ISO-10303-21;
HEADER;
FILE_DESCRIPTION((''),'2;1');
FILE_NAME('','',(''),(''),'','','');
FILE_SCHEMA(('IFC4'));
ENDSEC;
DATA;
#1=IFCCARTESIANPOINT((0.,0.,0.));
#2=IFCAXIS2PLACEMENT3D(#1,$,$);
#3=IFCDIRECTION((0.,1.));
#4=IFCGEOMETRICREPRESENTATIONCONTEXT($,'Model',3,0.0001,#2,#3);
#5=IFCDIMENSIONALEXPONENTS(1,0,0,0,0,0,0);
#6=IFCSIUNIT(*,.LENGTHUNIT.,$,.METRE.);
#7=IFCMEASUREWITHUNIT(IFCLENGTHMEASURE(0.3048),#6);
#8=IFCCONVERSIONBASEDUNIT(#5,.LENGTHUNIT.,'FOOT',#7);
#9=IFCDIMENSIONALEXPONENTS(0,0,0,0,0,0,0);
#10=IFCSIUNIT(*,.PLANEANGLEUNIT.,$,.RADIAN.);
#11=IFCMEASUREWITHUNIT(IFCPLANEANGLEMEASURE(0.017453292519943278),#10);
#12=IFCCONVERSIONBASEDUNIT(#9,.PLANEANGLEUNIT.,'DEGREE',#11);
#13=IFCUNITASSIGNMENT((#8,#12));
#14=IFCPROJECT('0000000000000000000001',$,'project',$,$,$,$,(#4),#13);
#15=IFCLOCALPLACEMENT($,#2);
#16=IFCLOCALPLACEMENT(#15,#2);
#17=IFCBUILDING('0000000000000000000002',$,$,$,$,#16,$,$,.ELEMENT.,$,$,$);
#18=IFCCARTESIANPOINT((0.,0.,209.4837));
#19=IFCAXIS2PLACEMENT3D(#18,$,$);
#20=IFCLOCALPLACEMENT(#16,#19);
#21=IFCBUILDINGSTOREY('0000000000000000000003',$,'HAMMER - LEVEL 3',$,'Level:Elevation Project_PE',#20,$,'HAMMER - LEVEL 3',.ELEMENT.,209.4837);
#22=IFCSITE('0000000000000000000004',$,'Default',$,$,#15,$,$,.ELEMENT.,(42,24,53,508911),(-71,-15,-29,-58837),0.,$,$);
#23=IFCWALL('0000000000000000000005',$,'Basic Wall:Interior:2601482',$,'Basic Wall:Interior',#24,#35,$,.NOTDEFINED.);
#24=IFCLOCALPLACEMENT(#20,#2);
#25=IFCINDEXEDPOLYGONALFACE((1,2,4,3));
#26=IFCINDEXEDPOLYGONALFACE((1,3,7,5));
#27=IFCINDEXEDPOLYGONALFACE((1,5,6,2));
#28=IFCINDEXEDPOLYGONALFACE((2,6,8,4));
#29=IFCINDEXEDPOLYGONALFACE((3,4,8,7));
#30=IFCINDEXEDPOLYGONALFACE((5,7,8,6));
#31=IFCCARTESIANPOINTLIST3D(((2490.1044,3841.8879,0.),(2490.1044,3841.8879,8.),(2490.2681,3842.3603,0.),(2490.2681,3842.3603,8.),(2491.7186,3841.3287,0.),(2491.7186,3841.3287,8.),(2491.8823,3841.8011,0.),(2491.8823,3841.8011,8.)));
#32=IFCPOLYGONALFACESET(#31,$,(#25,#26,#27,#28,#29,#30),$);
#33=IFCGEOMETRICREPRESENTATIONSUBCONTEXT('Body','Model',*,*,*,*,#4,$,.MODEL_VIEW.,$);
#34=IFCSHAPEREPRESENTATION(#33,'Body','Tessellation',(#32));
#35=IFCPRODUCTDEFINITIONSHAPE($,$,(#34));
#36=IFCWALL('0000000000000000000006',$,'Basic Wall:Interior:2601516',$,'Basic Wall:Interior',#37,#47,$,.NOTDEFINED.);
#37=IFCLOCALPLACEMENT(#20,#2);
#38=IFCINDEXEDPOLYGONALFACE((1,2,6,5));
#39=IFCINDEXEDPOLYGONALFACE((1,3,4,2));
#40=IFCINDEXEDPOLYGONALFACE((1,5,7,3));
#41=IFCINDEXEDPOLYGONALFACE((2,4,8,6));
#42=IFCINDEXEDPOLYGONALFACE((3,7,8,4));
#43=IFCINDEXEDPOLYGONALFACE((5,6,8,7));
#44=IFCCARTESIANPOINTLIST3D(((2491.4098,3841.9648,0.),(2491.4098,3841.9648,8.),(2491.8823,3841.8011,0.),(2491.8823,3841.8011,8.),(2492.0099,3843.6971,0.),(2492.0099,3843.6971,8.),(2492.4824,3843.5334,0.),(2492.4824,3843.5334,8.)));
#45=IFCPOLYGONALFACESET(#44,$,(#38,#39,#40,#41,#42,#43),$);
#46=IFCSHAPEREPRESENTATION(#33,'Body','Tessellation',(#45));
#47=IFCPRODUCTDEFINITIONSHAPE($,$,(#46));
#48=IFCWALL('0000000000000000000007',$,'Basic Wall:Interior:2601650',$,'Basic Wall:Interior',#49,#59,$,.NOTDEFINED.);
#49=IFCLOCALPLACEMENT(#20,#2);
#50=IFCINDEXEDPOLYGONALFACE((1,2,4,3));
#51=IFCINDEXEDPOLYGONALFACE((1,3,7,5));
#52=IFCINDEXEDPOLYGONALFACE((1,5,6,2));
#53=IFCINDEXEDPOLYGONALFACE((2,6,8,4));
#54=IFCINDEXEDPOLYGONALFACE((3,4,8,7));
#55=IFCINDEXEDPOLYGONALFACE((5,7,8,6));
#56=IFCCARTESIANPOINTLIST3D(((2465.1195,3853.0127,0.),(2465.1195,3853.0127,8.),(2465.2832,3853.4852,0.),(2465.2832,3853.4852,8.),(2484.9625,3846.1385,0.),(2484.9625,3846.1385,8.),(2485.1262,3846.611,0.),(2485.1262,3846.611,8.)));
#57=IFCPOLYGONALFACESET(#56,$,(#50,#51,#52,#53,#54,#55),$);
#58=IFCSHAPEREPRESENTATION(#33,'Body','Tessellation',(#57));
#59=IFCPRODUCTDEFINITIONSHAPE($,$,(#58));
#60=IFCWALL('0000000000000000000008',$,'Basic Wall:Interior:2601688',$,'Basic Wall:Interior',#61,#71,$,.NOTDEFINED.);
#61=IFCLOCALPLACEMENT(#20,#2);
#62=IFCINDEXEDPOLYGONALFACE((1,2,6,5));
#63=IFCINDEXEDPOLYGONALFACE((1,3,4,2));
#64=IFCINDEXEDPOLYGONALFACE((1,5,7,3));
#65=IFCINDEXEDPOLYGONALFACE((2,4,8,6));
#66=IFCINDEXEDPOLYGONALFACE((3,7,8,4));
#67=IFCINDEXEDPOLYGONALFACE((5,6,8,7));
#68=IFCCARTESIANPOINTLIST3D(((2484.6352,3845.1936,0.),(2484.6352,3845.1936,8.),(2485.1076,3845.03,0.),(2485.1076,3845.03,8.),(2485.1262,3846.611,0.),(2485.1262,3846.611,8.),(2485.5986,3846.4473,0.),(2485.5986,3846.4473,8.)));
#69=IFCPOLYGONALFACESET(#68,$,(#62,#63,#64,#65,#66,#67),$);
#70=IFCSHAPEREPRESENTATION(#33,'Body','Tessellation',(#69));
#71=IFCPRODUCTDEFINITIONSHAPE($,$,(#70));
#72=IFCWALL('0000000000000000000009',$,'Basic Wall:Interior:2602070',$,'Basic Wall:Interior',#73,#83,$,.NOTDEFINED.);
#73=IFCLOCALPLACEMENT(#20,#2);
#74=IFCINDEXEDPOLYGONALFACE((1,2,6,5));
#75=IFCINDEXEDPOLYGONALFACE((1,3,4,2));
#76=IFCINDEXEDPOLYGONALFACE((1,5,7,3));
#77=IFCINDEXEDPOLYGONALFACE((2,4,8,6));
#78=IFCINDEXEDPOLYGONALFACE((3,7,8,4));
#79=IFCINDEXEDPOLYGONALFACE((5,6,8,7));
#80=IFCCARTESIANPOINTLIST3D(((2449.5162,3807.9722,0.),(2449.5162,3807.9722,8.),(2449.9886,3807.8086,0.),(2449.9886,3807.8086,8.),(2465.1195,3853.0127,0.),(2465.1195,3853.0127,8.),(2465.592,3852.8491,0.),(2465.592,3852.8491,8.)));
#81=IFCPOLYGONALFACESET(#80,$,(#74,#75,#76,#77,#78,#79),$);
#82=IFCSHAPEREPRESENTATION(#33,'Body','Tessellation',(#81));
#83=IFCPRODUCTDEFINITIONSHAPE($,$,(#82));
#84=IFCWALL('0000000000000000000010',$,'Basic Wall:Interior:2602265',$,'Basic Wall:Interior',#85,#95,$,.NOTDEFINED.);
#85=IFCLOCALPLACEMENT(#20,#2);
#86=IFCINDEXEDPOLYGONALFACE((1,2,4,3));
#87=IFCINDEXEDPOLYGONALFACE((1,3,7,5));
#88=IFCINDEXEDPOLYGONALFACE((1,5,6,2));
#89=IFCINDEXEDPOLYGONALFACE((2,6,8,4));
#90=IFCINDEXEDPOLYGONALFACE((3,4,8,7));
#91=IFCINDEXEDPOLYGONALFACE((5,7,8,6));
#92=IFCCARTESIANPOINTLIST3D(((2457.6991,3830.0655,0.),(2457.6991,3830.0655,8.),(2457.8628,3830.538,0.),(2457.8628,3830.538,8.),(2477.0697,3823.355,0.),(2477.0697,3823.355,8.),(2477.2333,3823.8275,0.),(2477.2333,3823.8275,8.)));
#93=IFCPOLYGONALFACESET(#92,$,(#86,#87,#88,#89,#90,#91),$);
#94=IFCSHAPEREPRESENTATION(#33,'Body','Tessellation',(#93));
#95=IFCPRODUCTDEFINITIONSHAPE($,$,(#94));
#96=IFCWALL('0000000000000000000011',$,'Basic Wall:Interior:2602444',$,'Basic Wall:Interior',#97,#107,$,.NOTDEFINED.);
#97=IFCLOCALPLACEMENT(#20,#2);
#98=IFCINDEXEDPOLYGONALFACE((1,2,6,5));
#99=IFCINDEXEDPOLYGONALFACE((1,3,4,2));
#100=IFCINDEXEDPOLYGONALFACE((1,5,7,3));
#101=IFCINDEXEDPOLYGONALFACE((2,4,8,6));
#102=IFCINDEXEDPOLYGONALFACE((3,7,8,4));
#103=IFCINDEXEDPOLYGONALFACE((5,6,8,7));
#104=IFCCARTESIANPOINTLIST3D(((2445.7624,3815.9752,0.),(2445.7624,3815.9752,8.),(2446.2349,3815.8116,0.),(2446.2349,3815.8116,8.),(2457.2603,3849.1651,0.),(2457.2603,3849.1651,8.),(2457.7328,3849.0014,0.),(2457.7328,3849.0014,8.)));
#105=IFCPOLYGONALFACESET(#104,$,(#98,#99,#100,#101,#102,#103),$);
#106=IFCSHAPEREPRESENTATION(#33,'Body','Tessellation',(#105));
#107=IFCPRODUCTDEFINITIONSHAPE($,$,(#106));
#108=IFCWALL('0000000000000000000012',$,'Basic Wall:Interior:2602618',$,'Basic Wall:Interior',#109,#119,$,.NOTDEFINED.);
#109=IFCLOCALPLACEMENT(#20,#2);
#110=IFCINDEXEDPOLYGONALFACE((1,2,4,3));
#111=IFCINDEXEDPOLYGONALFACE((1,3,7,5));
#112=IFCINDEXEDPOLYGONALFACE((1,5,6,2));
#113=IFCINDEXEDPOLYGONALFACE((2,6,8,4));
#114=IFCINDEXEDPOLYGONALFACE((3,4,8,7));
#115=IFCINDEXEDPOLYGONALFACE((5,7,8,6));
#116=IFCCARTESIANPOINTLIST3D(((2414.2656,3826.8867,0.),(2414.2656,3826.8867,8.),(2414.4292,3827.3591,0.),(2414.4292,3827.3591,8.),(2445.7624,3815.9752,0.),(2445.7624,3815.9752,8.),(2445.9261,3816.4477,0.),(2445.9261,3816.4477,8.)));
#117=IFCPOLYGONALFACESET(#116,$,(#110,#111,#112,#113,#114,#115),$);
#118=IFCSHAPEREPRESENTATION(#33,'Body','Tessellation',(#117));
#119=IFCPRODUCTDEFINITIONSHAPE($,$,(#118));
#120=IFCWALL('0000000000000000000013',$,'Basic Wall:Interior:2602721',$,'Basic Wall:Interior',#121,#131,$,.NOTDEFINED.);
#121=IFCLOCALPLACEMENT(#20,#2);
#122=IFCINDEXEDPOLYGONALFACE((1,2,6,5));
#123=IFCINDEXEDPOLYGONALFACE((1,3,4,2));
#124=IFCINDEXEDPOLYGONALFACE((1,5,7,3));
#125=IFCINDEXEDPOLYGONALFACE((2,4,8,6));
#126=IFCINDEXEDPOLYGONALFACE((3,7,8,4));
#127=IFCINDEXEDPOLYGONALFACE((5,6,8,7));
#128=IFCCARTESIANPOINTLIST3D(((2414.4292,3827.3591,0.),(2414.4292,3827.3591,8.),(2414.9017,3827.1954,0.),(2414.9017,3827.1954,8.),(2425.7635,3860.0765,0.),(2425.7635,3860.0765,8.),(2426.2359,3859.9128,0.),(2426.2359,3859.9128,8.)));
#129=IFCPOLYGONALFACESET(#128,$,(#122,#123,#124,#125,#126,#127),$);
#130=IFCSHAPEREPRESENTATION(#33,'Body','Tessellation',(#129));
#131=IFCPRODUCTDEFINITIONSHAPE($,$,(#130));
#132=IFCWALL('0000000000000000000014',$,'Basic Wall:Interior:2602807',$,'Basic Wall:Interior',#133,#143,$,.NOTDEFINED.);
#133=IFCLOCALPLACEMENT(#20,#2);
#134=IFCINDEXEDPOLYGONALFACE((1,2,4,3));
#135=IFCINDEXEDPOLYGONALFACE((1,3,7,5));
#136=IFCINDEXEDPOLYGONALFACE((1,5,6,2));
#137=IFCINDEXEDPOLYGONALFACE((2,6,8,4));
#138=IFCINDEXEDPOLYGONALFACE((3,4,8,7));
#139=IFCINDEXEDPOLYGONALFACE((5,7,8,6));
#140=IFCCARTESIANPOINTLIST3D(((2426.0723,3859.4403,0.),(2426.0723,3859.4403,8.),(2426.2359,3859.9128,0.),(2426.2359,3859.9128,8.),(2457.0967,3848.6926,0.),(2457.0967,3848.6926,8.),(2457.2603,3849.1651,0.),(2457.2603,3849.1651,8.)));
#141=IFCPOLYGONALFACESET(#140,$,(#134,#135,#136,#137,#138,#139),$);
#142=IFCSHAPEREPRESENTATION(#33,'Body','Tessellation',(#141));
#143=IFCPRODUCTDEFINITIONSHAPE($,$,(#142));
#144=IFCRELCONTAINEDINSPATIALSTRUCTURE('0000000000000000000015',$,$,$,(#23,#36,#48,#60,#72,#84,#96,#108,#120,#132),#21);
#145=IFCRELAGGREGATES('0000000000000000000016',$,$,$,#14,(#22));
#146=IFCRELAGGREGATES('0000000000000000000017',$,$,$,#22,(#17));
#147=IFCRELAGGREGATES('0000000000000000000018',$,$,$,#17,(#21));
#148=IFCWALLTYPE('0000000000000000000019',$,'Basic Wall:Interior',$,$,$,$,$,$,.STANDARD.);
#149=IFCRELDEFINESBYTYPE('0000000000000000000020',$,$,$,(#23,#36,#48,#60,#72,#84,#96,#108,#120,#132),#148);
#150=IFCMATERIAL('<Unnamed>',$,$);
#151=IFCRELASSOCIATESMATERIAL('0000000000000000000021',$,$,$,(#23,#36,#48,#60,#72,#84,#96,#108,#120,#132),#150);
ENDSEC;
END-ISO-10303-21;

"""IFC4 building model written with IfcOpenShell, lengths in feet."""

from ifc_helpers import new_model, entity, si_unit, converted_unit, direction, frame, origin, place, context, subcontext, project, spatial, indexed_curve, outline, extrude, material, type_object, element, save


model = new_model("IFC4")

# Units and contexts
model_context = context("Model", 3, precision=0.0001, world=origin(), true_north=direction((0.0, 1.0)))
body_context = subcontext(model_context, "Body", "Model", "MODEL_VIEW")
ifc_project = project(units=[converted_unit("LENGTHUNIT", "FOOT", entity("IfcLengthMeasure", 0.3048), si_unit("LENGTHUNIT", "METRE"), dimensions=[1, 0, 0, 0, 0, 0, 0]), converted_unit("PLANEANGLEUNIT", "DEGREE", entity("IfcPlaneAngleMeasure", 0.017453292519943278), si_unit("PLANEANGLEUNIT", "RADIAN"), dimensions=[0, 0, 0, 0, 0, 0, 0])], contexts=[model_context])

# Site, building, storey
site_placement = place(None, origin())
site = spatial("IfcSite", under=ifc_project, at=site_placement, Name="Default", CompositionType="ELEMENT", RefLatitude=(42, 24, 53, 508911), RefLongitude=(-71, -15, -29, -58837), RefElevation=0.0)
building_placement = place(site_placement, origin())
building = spatial("IfcBuilding", under=site, at=building_placement, CompositionType="ELEMENT")
storey_placement = place(building_placement, frame((0.0, 0.0, 209.4837)))
storey = spatial("IfcBuildingStorey", under=building, at=storey_placement, Name="HAMMER - LEVEL 3", ObjectType="Level:Elevation Project_PE", LongName="HAMMER - LEVEL 3", CompositionType="ELEMENT", Elevation=209.4837)

# Walls
ifc_material = material(Name="<Unnamed>")
wall_type = type_object("IfcWallType", Name="Basic Wall:Interior", PredefinedType="STANDARD")
wall_1_placement = place(storey_placement, frame((2490.1862, 3842.1241, 0.0), z_axis=(0.0, 0.0, 1.0), x_axis=(0.944906, -0.327342, 0.0)))
element("IfcWall", 1, at=wall_1_placement, inside=storey, type_object=wall_type, material=ifc_material, Name="Basic Wall:Interior:2601482", ObjectType="Basic Wall:Interior", PredefinedType="NOTDEFINED", context=body_context, shape_type="SweptSolid", body=[
    extrude(outline(indexed_curve([(1.7083, 0.25), (0.0, 0.25), (0.0, -0.25), (1.7083, -0.25), (1.7083, 0.25)], self_intersect=False)), origin(), (0.0, 0.0, 1.0), 8.0),
])
wall_2_placement = place(storey_placement, frame((2491.646, 3841.883, 0.0), z_axis=(0.0, 0.0, 1.0), x_axis=(0.327342, 0.944906, 0.0)))
element("IfcWall", 2, at=wall_2_placement, inside=storey, type_object=wall_type, material=ifc_material, Name="Basic Wall:Interior:2601516", ObjectType="Basic Wall:Interior", PredefinedType="NOTDEFINED", context=body_context, shape_type="SweptSolid", body=[
    extrude(outline(indexed_curve([(1.8333, 0.25), (0.0, 0.25), (0.0, -0.25), (1.8333, -0.25), (1.8333, 0.25)], self_intersect=False)), origin(), (0.0, 0.0, 1.0), 8.0),
])
wall_3_placement = place(storey_placement, frame((2465.2013, 3853.249, 0.0), z_axis=(0.0, 0.0, 1.0), x_axis=(0.944906, -0.327342, 0.0)))
element("IfcWall", 3, at=wall_3_placement, inside=storey, type_object=wall_type, material=ifc_material, Name="Basic Wall:Interior:2601650", ObjectType="Basic Wall:Interior", PredefinedType="NOTDEFINED", context=body_context, shape_type="SweptSolid", body=[
    extrude(outline(indexed_curve([(21.0, 0.25), (0.0, 0.25), (0.0, -0.25), (21.0, -0.25), (21.0, 0.25)], self_intersect=False)), origin(), (0.0, 0.0, 1.0), 8.0),
])
wall_4_placement = place(storey_placement, frame((2485.3624, 3846.5292, 0.0), z_axis=(0.0, 0.0, 1.0), x_axis=(-0.327342, -0.944906, 0.0)))
element("IfcWall", 4, at=wall_4_placement, inside=storey, type_object=wall_type, material=ifc_material, Name="Basic Wall:Interior:2601688", ObjectType="Basic Wall:Interior", PredefinedType="NOTDEFINED", context=body_context, shape_type="SweptSolid", body=[
    extrude(outline(indexed_curve([(1.5, 0.25), (0.0, 0.25), (0.0, -0.25), (1.5, -0.25), (1.5, 0.25)], self_intersect=False)), origin(), (0.0, 0.0, 1.0), 8.0),
])
wall_5_placement = place(storey_placement, frame((2449.7524, 3807.8904, 0.0), z_axis=(0.0, 0.0, 1.0), x_axis=(0.327342, 0.944906, 0.0)))
element("IfcWall", 5, at=wall_5_placement, inside=storey, type_object=wall_type, material=ifc_material, Name="Basic Wall:Interior:2602070", ObjectType="Basic Wall:Interior", PredefinedType="NOTDEFINED", context=body_context, shape_type="SweptSolid", body=[
    extrude(outline(indexed_curve([(47.6667, 0.25), (0.0, 0.25), (0.0, -0.25), (47.6667, -0.25), (47.6667, 0.25)], self_intersect=False)), origin(), (0.0, 0.0, 1.0), 8.0),
])
wall_6_placement = place(storey_placement, frame((2457.7809, 3830.3017, 0.0), z_axis=(0.0, 0.0, 1.0), x_axis=(0.944906, -0.327342, 0.0)))
element("IfcWall", 6, at=wall_6_placement, inside=storey, type_object=wall_type, material=ifc_material, Name="Basic Wall:Interior:2602265", ObjectType="Basic Wall:Interior", PredefinedType="NOTDEFINED", context=body_context, shape_type="SweptSolid", body=[
    extrude(outline(indexed_curve([(20.5, 0.25), (0.0, 0.25), (0.0, -0.25), (20.5, -0.25), (20.5, 0.25)], self_intersect=False)), origin(), (0.0, 0.0, 1.0), 8.0),
])
wall_7_placement = place(storey_placement, frame((2457.4966, 3849.0832, 0.0), z_axis=(0.0, 0.0, 1.0), x_axis=(-0.327342, -0.944906, 0.0)))
element("IfcWall", 7, at=wall_7_placement, inside=storey, type_object=wall_type, material=ifc_material, Name="Basic Wall:Interior:2602444", ObjectType="Basic Wall:Interior", PredefinedType="NOTDEFINED", context=body_context, shape_type="SweptSolid", body=[
    extrude(outline(indexed_curve([(35.125, 0.25), (0.0, 0.25), (0.0, -0.25), (35.125, -0.25), (35.125, 0.25)], self_intersect=False)), origin(), (0.0, 0.0, 1.0), 8.0),
])
wall_8_placement = place(storey_placement, frame((2445.8443, 3816.2115, 0.0), z_axis=(0.0, 0.0, 1.0), x_axis=(-0.944906, 0.327342, 0.0)))
element("IfcWall", 8, at=wall_8_placement, inside=storey, type_object=wall_type, material=ifc_material, Name="Basic Wall:Interior:2602618", ObjectType="Basic Wall:Interior", PredefinedType="NOTDEFINED", context=body_context, shape_type="SweptSolid", body=[
    extrude(outline(indexed_curve([(33.3333, 0.25), (0.0, 0.25), (0.0, -0.25), (33.3333, -0.25), (33.3333, 0.25)], self_intersect=False)), origin(), (0.0, 0.0, 1.0), 8.0),
])
wall_9_placement = place(storey_placement, frame((2414.6655, 3827.2773, 0.0), z_axis=(0.0, 0.0, 1.0), x_axis=(0.327342, 0.944906, 0.0)))
element("IfcWall", 9, at=wall_9_placement, inside=storey, type_object=wall_type, material=ifc_material, Name="Basic Wall:Interior:2602721", ObjectType="Basic Wall:Interior", PredefinedType="NOTDEFINED", context=body_context, shape_type="SweptSolid", body=[
    extrude(outline(indexed_curve([(34.625, 0.25), (0.0, 0.25), (0.0, -0.25), (34.625, -0.25), (34.625, 0.25)], self_intersect=False)), origin(), (0.0, 0.0, 1.0), 8.0),
])
wall_10_placement = place(storey_placement, frame((2426.1541, 3859.6766, 0.0), z_axis=(0.0, 0.0, 1.0), x_axis=(0.944906, -0.327342, 0.0)))
element("IfcWall", 10, at=wall_10_placement, inside=storey, type_object=wall_type, material=ifc_material, Name="Basic Wall:Interior:2602807", ObjectType="Basic Wall:Interior", PredefinedType="NOTDEFINED", context=body_context, shape_type="SweptSolid", body=[
    extrude(outline(indexed_curve([(32.8333, 0.25), (0.0, 0.25), (0.0, -0.25), (32.8333, -0.25), (32.8333, 0.25)], self_intersect=False)), origin(), (0.0, 0.0, 1.0), 8.0),
])

save(model, "model.ifc")
